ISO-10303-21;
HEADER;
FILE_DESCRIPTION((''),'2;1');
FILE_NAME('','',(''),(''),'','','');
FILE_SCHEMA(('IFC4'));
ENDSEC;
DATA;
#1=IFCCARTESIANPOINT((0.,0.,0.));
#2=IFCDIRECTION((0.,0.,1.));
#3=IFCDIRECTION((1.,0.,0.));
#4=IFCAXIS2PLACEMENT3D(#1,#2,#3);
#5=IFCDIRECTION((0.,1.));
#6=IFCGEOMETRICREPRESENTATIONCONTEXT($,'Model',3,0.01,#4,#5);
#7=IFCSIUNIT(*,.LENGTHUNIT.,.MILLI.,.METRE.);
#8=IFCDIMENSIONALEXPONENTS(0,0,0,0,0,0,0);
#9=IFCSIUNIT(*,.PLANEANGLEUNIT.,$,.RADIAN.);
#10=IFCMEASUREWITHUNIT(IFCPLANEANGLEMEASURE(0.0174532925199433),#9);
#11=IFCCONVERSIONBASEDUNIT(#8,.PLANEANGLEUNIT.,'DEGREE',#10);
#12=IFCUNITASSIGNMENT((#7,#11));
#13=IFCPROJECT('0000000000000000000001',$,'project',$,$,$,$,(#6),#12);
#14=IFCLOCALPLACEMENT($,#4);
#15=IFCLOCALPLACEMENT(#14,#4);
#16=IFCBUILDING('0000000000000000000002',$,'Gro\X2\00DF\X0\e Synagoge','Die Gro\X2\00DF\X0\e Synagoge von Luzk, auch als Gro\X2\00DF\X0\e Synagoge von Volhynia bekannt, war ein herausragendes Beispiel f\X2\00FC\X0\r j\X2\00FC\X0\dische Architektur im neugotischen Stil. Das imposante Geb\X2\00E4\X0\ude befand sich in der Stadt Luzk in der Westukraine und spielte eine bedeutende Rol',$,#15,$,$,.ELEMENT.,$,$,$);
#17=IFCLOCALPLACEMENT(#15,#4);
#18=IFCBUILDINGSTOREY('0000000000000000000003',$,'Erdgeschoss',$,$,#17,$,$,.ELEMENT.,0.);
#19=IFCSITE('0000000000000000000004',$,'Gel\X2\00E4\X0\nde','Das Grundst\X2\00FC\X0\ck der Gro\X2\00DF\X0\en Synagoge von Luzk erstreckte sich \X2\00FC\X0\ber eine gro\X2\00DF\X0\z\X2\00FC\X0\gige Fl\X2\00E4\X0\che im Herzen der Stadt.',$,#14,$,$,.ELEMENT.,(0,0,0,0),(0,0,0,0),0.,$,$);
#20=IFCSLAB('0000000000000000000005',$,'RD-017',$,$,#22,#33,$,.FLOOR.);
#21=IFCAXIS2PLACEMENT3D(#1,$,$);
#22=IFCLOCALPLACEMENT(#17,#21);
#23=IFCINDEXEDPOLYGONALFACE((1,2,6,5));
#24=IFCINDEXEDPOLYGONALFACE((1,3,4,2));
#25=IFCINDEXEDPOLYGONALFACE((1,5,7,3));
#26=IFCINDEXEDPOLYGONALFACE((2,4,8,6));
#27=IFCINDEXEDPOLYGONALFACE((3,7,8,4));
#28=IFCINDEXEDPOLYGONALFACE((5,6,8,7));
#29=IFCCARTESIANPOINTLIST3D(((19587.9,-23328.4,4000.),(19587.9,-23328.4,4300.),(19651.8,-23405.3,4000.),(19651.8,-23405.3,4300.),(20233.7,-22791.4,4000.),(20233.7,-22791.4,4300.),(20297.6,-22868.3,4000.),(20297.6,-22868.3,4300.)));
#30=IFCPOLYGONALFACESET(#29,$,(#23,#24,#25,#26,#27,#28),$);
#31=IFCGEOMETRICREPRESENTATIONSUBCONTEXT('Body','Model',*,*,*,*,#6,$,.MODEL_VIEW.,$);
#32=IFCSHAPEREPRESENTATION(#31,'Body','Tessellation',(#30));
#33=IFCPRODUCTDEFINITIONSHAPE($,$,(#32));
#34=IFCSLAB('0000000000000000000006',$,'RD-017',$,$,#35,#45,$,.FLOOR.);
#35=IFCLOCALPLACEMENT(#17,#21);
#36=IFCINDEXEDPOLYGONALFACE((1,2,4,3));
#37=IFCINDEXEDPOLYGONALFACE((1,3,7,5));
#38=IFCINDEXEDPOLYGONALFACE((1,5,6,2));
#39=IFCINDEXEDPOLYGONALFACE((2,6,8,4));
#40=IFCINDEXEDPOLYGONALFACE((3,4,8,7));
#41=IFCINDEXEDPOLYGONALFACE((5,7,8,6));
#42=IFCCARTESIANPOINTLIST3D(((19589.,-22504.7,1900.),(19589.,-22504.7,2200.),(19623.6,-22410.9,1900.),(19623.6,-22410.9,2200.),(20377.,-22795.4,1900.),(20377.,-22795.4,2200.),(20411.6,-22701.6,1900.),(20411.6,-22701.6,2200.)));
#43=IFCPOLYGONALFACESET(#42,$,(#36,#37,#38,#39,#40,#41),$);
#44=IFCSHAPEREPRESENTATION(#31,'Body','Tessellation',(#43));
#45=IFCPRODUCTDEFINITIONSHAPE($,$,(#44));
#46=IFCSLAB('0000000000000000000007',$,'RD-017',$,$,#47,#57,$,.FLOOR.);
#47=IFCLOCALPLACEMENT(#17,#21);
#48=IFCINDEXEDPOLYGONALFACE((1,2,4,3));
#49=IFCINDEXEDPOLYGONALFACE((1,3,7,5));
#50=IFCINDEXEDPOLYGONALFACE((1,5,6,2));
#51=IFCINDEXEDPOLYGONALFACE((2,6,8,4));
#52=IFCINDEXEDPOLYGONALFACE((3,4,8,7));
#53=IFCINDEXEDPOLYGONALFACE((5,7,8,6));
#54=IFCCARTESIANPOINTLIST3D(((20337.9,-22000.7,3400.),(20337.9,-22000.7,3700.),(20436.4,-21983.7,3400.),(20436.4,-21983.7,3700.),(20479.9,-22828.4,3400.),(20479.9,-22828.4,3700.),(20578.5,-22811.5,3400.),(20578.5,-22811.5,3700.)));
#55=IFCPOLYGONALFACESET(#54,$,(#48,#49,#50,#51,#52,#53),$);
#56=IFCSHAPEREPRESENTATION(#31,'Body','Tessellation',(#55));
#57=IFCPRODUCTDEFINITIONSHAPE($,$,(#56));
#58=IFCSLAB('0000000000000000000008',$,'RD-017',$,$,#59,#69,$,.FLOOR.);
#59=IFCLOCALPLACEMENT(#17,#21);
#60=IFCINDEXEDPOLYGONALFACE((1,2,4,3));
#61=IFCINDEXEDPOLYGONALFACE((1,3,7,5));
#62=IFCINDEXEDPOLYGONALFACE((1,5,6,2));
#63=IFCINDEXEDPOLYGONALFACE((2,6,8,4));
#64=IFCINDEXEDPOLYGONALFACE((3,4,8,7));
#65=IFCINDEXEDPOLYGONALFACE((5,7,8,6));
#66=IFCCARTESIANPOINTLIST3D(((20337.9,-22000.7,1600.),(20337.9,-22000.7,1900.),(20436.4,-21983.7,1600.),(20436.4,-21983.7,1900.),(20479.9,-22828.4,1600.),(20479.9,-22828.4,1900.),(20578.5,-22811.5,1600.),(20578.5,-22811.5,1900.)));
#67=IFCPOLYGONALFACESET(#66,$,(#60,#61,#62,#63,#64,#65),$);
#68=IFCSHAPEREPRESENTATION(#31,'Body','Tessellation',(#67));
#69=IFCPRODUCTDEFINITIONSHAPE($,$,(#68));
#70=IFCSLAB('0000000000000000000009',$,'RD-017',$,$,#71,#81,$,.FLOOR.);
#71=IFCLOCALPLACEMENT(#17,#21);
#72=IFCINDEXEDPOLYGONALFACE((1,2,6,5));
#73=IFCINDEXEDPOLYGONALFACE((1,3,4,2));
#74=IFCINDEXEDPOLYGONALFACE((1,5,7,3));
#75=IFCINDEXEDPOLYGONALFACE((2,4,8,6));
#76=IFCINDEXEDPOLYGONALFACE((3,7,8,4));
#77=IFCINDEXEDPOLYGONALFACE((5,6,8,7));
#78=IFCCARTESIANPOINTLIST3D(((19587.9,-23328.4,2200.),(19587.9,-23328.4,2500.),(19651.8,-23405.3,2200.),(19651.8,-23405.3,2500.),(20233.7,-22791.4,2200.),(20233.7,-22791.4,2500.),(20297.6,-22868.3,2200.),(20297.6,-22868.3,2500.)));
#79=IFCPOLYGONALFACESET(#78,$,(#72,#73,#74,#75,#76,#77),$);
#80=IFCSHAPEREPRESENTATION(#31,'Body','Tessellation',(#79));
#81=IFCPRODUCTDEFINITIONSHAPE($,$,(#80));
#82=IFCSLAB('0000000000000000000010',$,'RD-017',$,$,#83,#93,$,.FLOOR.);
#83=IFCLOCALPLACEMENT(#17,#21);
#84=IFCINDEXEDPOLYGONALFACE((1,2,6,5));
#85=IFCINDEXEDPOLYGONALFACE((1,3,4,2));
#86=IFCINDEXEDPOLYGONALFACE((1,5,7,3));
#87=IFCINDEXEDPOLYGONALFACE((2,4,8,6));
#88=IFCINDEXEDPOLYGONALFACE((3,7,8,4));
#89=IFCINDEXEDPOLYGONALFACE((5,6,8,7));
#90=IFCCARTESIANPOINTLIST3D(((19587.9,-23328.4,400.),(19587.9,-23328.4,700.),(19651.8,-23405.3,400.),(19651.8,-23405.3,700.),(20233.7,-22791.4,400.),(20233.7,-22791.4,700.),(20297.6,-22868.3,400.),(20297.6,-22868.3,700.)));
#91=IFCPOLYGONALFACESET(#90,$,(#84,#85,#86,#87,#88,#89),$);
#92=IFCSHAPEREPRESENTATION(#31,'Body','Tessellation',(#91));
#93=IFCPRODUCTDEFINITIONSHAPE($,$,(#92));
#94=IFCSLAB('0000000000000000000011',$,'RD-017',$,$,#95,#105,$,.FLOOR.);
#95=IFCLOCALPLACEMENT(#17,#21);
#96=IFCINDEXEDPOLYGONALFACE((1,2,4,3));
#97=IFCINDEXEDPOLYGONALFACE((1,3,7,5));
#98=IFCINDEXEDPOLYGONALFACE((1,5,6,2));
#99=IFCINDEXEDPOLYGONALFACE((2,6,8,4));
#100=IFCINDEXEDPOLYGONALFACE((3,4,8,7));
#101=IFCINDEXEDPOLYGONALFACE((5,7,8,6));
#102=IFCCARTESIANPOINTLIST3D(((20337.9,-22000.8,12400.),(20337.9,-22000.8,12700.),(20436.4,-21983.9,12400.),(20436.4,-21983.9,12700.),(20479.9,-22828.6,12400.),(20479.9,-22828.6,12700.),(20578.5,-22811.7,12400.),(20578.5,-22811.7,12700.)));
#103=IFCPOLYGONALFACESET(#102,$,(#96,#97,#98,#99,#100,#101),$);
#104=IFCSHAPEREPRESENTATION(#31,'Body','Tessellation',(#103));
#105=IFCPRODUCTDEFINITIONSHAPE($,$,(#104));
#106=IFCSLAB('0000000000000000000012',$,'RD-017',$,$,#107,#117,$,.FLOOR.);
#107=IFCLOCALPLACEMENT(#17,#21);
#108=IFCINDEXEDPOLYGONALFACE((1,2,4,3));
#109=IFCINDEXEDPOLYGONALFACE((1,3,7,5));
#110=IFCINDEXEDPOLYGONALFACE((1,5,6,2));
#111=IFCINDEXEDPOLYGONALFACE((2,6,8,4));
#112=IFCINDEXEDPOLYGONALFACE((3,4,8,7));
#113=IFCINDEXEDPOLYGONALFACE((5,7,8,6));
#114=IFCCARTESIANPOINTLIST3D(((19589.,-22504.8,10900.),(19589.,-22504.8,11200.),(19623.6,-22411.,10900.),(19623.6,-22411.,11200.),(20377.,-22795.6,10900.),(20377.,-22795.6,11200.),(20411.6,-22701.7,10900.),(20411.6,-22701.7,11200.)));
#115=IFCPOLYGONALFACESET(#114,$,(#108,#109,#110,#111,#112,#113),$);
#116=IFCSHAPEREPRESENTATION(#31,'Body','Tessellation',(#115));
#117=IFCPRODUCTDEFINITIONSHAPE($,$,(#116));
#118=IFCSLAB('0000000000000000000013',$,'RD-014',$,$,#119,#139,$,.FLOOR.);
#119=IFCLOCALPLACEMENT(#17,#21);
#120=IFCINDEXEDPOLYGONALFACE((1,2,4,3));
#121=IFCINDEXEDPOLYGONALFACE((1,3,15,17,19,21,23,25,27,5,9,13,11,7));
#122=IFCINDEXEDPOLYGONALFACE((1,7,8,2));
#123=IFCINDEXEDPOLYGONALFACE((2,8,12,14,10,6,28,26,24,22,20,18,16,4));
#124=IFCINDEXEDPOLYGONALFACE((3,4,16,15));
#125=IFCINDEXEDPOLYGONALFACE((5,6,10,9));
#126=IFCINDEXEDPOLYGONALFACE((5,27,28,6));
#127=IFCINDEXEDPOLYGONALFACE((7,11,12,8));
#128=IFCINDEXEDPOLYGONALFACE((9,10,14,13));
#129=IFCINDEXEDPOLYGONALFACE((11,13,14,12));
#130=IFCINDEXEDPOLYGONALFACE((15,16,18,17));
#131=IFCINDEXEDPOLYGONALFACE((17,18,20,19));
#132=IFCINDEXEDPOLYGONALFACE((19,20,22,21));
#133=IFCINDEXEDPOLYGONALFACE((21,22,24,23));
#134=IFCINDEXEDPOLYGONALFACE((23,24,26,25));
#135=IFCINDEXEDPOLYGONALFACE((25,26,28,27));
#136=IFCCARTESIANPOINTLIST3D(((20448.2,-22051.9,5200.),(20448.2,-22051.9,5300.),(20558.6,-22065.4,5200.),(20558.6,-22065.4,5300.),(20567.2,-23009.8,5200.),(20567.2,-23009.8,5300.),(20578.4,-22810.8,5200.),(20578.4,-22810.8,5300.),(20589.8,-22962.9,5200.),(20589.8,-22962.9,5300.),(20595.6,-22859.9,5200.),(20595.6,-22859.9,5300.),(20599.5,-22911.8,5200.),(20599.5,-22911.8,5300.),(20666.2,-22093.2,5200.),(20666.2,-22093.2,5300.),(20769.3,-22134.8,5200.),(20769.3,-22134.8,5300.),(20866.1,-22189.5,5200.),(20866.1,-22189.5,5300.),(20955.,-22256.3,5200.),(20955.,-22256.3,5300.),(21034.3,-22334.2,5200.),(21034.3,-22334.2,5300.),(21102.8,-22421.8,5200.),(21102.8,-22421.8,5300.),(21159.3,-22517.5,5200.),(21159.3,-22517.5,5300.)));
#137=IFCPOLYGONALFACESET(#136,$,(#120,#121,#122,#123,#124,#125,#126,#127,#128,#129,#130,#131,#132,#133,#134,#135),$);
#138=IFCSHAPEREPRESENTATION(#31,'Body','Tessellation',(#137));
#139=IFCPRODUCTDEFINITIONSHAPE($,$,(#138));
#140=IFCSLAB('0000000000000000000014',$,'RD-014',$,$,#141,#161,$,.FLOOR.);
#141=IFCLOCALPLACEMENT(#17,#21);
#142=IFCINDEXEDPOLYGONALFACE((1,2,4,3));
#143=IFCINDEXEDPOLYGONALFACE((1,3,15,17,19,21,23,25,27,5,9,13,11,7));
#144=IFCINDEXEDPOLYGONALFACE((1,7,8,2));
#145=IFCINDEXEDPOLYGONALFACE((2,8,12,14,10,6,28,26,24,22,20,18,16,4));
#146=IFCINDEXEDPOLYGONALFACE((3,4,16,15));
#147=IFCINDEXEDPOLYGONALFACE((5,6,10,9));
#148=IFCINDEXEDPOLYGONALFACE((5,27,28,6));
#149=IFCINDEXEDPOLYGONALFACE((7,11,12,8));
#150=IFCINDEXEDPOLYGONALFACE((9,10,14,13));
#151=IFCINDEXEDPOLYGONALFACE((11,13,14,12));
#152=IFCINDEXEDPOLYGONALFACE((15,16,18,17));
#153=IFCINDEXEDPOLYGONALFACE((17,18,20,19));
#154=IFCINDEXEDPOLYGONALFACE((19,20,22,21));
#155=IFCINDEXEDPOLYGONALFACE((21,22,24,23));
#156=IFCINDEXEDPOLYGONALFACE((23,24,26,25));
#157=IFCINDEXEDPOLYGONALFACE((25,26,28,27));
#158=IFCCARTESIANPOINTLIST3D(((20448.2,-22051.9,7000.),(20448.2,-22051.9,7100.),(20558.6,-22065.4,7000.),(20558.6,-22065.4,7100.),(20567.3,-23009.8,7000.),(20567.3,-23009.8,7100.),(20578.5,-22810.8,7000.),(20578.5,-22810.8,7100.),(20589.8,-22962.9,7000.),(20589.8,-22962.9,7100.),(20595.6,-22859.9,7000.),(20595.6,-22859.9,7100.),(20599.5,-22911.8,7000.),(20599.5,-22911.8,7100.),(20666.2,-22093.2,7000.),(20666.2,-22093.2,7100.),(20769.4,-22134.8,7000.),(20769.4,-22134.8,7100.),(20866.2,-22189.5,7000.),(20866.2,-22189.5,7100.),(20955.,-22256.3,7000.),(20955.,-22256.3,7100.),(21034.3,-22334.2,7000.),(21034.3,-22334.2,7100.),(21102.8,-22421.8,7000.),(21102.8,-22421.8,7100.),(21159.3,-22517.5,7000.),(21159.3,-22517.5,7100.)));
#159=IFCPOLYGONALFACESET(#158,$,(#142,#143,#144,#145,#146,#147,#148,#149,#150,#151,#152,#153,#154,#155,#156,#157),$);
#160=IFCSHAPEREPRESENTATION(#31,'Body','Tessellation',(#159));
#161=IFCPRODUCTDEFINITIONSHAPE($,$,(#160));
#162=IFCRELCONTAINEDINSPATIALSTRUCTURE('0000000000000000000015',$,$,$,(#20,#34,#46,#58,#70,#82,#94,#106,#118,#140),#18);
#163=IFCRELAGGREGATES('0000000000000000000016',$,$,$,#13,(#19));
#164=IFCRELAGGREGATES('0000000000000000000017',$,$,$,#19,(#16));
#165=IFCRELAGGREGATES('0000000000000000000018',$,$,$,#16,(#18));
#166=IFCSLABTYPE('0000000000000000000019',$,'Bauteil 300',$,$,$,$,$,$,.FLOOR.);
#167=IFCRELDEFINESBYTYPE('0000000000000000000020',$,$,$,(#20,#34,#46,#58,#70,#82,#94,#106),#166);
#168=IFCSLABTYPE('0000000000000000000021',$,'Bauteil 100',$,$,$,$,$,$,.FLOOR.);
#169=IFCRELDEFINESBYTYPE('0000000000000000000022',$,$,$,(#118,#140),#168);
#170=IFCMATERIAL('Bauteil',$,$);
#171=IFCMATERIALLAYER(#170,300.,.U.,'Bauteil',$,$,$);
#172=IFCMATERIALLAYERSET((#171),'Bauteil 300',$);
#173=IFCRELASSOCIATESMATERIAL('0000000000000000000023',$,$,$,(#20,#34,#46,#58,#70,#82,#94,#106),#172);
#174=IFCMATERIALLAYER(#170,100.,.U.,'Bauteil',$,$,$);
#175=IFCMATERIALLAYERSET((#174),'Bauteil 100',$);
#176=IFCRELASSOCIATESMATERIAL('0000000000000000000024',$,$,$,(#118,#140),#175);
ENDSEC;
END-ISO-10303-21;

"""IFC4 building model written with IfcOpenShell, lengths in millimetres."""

from ifc_helpers import new_model, entity, si_unit, converted_unit, direction, frame, origin_with_axes, place, context, subcontext, project, spatial, line, arc, indexed_curve, outline, extrude, material, layer, layer_set, layer_usage, type_object, element, save


model = new_model("IFC4")

# Units and contexts
model_context = context("Model", 3, precision=0.01, world=origin_with_axes(), true_north=direction((0.0, 1.0)))
body_context = subcontext(model_context, "Body", "Model", "MODEL_VIEW")
ifc_project = project(units=[si_unit("LENGTHUNIT", "METRE", prefix="MILLI"), converted_unit("PLANEANGLEUNIT", "DEGREE", entity("IfcPlaneAngleMeasure", 0.0174532925199433), si_unit("PLANEANGLEUNIT", "RADIAN"), dimensions=[0, 0, 0, 0, 0, 0, 0])], contexts=[model_context])

# Site, building, storey
site_placement = place(None, origin_with_axes())
site = spatial("IfcSite", under=ifc_project, at=site_placement, Name="Gelände", Description="Das Grundstück der Großen Synagoge von Luzk erstreckte sich über eine großzügige Fläche im Herzen der Stadt.", CompositionType="ELEMENT", RefLatitude=(0, 0, 0, 0), RefLongitude=(0, 0, 0, 0), RefElevation=0.0)
building_placement = place(site_placement, origin_with_axes())
building = spatial("IfcBuilding", under=site, at=building_placement, Name="Große Synagoge", Description="Die Große Synagoge von Luzk, auch als Große Synagoge von Volhynia bekannt, war ein herausragendes Beispiel für jüdische Architektur im neugotischen Stil. Das imposante Gebäude befand sich in der Stadt Luzk in der Westukraine und spielte eine bedeutende Rol", CompositionType="ELEMENT")
storey_placement = place(building_placement, origin_with_axes())
storey = spatial("IfcBuildingStorey", under=building, at=storey_placement, Name="Erdgeschoss", CompositionType="ELEMENT", Elevation=0.0)

# Slabs
ifc_material = material(Name="Bauteil")
ifc_layer_1 = layer(ifc_material, 300.0, ventilated="UNKNOWN", Name="Bauteil")
ifc_layer_set_1 = layer_set([ifc_layer_1], Name="Bauteil 300")
slab_type_1 = type_object("IfcSlabType", Name="Bauteil 300", PredefinedType="FLOOR")
ifc_layer_usage_1 = layer_usage(ifc_layer_set_1, "AXIS3", "NEGATIVE", 300.0)
slab_1_placement = place(storey_placement, frame((20297.6, -22868.3, 4300.0), z_axis=(0.0, 0.0, 1.0), x_axis=(1.0, 0.0, 0.0)))
element("IfcSlab", 1, at=slab_1_placement, inside=storey, type_object=slab_type_1, material=ifc_layer_usage_1, Name="RD-017", PredefinedType="FLOOR", context=body_context, shape_type="SweptSolid", body=[
    extrude(outline(indexed_curve([(0.0, 0.0), (-63.9, 76.9), (-709.7, -460.1), (-645.8, -537.0)], segments=[line(1, 2, 3, 4, 1)])), frame((0.0, 0.0, -300.0), z_axis=(0.0, 0.0, 1.0), x_axis=(1.0, 0.0, 0.0)), (0.0, 0.0, 1.0), 300.0),
])
ifc_layer_usage_2 = layer_usage(ifc_layer_set_1, "AXIS3", "NEGATIVE", 300.0)
slab_2_placement = place(storey_placement, frame((20377.0, -22795.4, 2200.0), z_axis=(0.0, 0.0, 1.0), x_axis=(1.0, 0.0, 0.0)))
element("IfcSlab", 2, at=slab_2_placement, inside=storey, type_object=slab_type_1, material=ifc_layer_usage_2, Name="RD-017", PredefinedType="FLOOR", context=body_context, shape_type="SweptSolid", body=[
    extrude(outline(indexed_curve([(0.0, 0.0), (34.6, 93.8), (-753.4, 384.5), (-788.0, 290.7)], segments=[line(1, 2, 3, 4, 1)])), frame((0.0, 0.0, -300.0), z_axis=(0.0, 0.0, 1.0), x_axis=(1.0, 0.0, 0.0)), (0.0, 0.0, 1.0), 300.0),
])
ifc_layer_usage_3 = layer_usage(ifc_layer_set_1, "AXIS3", "NEGATIVE", 300.0)
slab_3_placement = place(storey_placement, frame((20479.9, -22828.4, 3700.0), z_axis=(0.0, 0.0, 1.0), x_axis=(1.0, 0.0, 0.0)))
element("IfcSlab", 3, at=slab_3_placement, inside=storey, type_object=slab_type_1, material=ifc_layer_usage_3, Name="RD-017", PredefinedType="FLOOR", context=body_context, shape_type="SweptSolid", body=[
    extrude(outline(indexed_curve([(0.0, 0.0), (98.6, 16.9), (-43.5, 844.7), (-142.1, 827.8)], segments=[line(1, 2, 3, 4, 1)])), frame((0.0, 0.0, -300.0), z_axis=(0.0, 0.0, 1.0), x_axis=(1.0, 0.0, 0.0)), (0.0, 0.0, 1.0), 300.0),
])
ifc_layer_usage_4 = layer_usage(ifc_layer_set_1, "AXIS3", "NEGATIVE", 300.0)
slab_4_placement = place(storey_placement, frame((20479.9, -22828.4, 1900.0), z_axis=(0.0, 0.0, 1.0), x_axis=(1.0, 0.0, 0.0)))
element("IfcSlab", 4, at=slab_4_placement, inside=storey, type_object=slab_type_1, material=ifc_layer_usage_4, Name="RD-017", PredefinedType="FLOOR", context=body_context, shape_type="SweptSolid", body=[
    extrude(outline(indexed_curve([(0.0, 0.0), (98.6, 16.9), (-43.5, 844.7), (-142.1, 827.8)], segments=[line(1, 2, 3, 4, 1)])), frame((0.0, 0.0, -300.0), z_axis=(0.0, 0.0, 1.0), x_axis=(1.0, 0.0, 0.0)), (0.0, 0.0, 1.0), 300.0),
])
ifc_layer_usage_5 = layer_usage(ifc_layer_set_1, "AXIS3", "NEGATIVE", 300.0)
slab_5_placement = place(storey_placement, frame((20297.6, -22868.3, 2500.0), z_axis=(0.0, 0.0, 1.0), x_axis=(1.0, 0.0, 0.0)))
element("IfcSlab", 5, at=slab_5_placement, inside=storey, type_object=slab_type_1, material=ifc_layer_usage_5, Name="RD-017", PredefinedType="FLOOR", context=body_context, shape_type="SweptSolid", body=[
    extrude(outline(indexed_curve([(0.0, 0.0), (-63.9, 76.9), (-709.7, -460.1), (-645.8, -537.0)], segments=[line(1, 2, 3, 4, 1)])), frame((0.0, 0.0, -300.0), z_axis=(0.0, 0.0, 1.0), x_axis=(1.0, 0.0, 0.0)), (0.0, 0.0, 1.0), 300.0),
])
ifc_layer_usage_6 = layer_usage(ifc_layer_set_1, "AXIS3", "NEGATIVE", 300.0)
slab_6_placement = place(storey_placement, frame((20297.6, -22868.3, 700.0), z_axis=(0.0, 0.0, 1.0), x_axis=(1.0, 0.0, 0.0)))
element("IfcSlab", 6, at=slab_6_placement, inside=storey, type_object=slab_type_1, material=ifc_layer_usage_6, Name="RD-017", PredefinedType="FLOOR", context=body_context, shape_type="SweptSolid", body=[
    extrude(outline(indexed_curve([(0.0, 0.0), (-63.9, 76.9), (-709.7, -460.1), (-645.8, -537.0)], segments=[line(1, 2, 3, 4, 1)])), frame((0.0, 0.0, -300.0), z_axis=(0.0, 0.0, 1.0), x_axis=(1.0, 0.0, 0.0)), (0.0, 0.0, 1.0), 300.0),
])
ifc_layer_usage_7 = layer_usage(ifc_layer_set_1, "AXIS3", "NEGATIVE", 300.0)
slab_7_placement = place(storey_placement, frame((20479.9, -22828.6, 12700.0), z_axis=(0.0, 0.0, 1.0), x_axis=(1.0, 0.0, 0.0)))
element("IfcSlab", 7, at=slab_7_placement, inside=storey, type_object=slab_type_1, material=ifc_layer_usage_7, Name="RD-017", PredefinedType="FLOOR", context=body_context, shape_type="SweptSolid", body=[
    extrude(outline(indexed_curve([(0.0, 0.0), (98.6, 16.9), (-43.5, 844.7), (-142.1, 827.8)], segments=[line(1, 2, 3, 4, 1)])), frame((0.0, 0.0, -300.0), z_axis=(0.0, 0.0, 1.0), x_axis=(1.0, 0.0, 0.0)), (0.0, 0.0, 1.0), 300.0),
])
ifc_layer_usage_8 = layer_usage(ifc_layer_set_1, "AXIS3", "NEGATIVE", 300.0)
slab_8_placement = place(storey_placement, frame((20377.0, -22795.6, 11200.0), z_axis=(0.0, 0.0, 1.0), x_axis=(1.0, 0.0, 0.0)))
element("IfcSlab", 8, at=slab_8_placement, inside=storey, type_object=slab_type_1, material=ifc_layer_usage_8, Name="RD-017", PredefinedType="FLOOR", context=body_context, shape_type="SweptSolid", body=[
    extrude(outline(indexed_curve([(0.0, 0.0), (34.6, 93.8), (-753.4, 384.5), (-788.0, 290.7)], segments=[line(1, 2, 3, 4, 1)])), frame((0.0, 0.0, -300.0), z_axis=(0.0, 0.0, 1.0), x_axis=(1.0, 0.0, 0.0)), (0.0, 0.0, 1.0), 300.0),
])
ifc_layer_2 = layer(ifc_material, 100.0, ventilated="UNKNOWN", Name="Bauteil")
ifc_layer_set_2 = layer_set([ifc_layer_2], Name="Bauteil 100")
ifc_layer_usage_9 = layer_usage(ifc_layer_set_2, "AXIS3", "NEGATIVE", 100.0)
slab_type_2 = type_object("IfcSlabType", Name="Bauteil 100", PredefinedType="FLOOR")
slab_9_placement = place(storey_placement, frame((21159.3, -22517.5, 5300.0), z_axis=(0.0, 0.0, 1.0), x_axis=(1.0, 0.0, 0.0)))
element("IfcSlab", 9, at=slab_9_placement, inside=storey, type_object=slab_type_2, material=ifc_layer_usage_9, Name="RD-014", PredefinedType="FLOOR", context=body_context, shape_type="SweptSolid", body=[
    extrude(outline(indexed_curve([(0.0, 0.0), (-293.2, 328.1), (-711.1, 465.6), (-580.9, -293.2), (-559.8, -394.2), (-592.1, -492.2)], segments=[arc(1, 2, 3), line(3, 4), arc(4, 5, 6), line(6, 1)])), frame((0.0, 0.0, -100.0), z_axis=(0.0, 0.0, 1.0), x_axis=(1.0, 0.0, 0.0)), (0.0, 0.0, 1.0), 100.0),
])
ifc_layer_usage_10 = layer_usage(ifc_layer_set_2, "AXIS3", "NEGATIVE", 100.0)
slab_10_placement = place(storey_placement, frame((21159.3, -22517.5, 7100.0), z_axis=(0.0, 0.0, 1.0), x_axis=(1.0, 0.0, 0.0)))
element("IfcSlab", 10, at=slab_10_placement, inside=storey, type_object=slab_type_2, material=ifc_layer_usage_10, Name="RD-014", PredefinedType="FLOOR", context=body_context, shape_type="SweptSolid", body=[
    extrude(outline(indexed_curve([(0.0, 0.0), (-293.2, 328.1), (-711.1, 465.6), (-580.9, -293.2), (-559.8, -394.2), (-592.1, -492.2)], segments=[arc(1, 2, 3), line(3, 4), arc(4, 5, 6), line(6, 1)])), frame((0.0, 0.0, -100.0), z_axis=(0.0, 0.0, 1.0), x_axis=(1.0, 0.0, 0.0)), (0.0, 0.0, 1.0), 100.0),
])

save(model, "model.ifc")
